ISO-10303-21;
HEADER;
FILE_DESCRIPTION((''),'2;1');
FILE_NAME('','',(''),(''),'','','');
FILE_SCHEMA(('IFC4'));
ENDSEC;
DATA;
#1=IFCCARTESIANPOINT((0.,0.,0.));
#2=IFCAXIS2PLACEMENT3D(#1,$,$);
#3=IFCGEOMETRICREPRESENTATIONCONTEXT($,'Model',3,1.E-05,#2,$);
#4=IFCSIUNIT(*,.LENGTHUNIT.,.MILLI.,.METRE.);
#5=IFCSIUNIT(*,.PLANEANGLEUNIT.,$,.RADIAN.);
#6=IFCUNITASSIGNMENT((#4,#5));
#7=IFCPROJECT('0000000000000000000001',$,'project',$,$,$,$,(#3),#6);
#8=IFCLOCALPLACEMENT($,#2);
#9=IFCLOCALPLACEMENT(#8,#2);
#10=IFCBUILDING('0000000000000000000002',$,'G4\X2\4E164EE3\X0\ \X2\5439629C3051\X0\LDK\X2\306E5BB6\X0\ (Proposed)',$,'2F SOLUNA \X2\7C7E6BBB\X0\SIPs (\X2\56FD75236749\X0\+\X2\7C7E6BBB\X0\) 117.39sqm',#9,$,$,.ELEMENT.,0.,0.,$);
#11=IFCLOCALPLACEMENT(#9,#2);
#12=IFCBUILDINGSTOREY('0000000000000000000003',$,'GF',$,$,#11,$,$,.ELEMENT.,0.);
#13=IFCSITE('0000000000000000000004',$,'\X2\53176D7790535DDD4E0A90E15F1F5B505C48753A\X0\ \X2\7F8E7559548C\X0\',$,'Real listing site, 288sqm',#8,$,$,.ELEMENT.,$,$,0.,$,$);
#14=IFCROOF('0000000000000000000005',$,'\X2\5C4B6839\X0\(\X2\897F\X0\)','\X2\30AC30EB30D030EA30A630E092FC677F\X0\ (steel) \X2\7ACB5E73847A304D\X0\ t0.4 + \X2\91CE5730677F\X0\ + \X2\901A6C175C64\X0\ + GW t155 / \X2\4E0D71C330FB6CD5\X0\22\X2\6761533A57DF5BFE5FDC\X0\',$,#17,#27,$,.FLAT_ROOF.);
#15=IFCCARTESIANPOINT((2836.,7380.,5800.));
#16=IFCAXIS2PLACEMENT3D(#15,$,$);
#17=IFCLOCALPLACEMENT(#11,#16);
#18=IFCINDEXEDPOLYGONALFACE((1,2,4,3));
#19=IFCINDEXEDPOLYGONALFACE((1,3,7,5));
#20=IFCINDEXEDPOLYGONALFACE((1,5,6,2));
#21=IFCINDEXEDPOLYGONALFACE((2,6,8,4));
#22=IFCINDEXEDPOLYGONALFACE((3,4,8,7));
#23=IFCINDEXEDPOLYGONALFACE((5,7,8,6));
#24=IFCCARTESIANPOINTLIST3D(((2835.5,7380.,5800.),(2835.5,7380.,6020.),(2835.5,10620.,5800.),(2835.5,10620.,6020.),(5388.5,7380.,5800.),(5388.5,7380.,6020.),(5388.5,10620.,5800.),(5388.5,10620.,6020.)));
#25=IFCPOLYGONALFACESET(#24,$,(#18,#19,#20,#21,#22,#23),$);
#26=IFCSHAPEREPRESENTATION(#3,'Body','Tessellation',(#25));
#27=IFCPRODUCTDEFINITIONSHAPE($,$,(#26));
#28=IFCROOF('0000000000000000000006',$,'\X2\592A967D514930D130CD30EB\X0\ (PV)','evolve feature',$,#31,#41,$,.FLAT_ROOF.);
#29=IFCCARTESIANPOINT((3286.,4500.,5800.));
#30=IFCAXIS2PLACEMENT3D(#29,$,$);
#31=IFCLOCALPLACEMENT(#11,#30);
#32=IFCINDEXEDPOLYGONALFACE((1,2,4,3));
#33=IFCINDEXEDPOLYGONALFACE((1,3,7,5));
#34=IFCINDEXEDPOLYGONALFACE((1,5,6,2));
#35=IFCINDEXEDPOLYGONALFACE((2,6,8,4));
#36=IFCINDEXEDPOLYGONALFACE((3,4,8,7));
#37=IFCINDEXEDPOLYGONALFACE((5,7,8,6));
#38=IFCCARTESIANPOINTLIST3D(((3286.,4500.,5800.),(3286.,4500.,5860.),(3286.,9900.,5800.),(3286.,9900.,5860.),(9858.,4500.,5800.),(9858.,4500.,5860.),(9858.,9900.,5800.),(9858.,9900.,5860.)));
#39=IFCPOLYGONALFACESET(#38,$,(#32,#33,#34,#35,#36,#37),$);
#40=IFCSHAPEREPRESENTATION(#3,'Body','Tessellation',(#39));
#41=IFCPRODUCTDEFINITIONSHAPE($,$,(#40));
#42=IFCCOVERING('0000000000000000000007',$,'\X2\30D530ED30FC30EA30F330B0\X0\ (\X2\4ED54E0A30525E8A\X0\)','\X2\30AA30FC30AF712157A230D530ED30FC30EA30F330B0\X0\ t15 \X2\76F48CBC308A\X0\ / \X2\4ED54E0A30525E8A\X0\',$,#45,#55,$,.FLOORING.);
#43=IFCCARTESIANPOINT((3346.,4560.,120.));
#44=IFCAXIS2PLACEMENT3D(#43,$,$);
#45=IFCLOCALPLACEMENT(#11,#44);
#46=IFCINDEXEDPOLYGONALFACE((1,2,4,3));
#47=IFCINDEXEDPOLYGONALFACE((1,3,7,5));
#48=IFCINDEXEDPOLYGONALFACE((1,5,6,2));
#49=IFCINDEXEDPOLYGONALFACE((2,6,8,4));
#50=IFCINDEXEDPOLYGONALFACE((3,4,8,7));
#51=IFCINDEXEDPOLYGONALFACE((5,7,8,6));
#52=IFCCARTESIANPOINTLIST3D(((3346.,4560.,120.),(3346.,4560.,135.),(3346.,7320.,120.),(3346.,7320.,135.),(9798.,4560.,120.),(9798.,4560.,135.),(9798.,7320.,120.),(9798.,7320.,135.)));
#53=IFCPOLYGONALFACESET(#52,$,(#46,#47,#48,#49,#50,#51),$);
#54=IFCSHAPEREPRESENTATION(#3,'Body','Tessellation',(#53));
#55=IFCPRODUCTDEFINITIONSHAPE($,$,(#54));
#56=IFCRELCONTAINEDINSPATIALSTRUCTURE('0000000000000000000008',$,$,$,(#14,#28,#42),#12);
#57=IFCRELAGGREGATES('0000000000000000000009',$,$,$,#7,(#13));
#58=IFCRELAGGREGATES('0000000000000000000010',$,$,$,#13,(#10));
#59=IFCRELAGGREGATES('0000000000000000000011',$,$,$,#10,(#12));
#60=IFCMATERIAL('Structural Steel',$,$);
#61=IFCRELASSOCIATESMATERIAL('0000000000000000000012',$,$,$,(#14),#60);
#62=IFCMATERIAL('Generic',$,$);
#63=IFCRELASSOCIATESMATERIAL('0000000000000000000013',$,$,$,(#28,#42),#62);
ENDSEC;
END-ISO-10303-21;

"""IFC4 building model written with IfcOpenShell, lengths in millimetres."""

from ifc_helpers import new_model, si_unit, frame, frame_2d, origin, place, context, project, spatial, rectangle, extrude, material, element, save


model = new_model("IFC4")

# Units and contexts
model_context = context("Model", 3, precision=1e-05, world=origin())
ifc_project = project(units=[si_unit("LENGTHUNIT", "METRE", prefix="MILLI"), si_unit("PLANEANGLEUNIT", "RADIAN")], contexts=[model_context])

# Site, building, storey
site_placement = place(None, origin())
site = spatial("IfcSite", under=ifc_project, at=site_placement, Name="北海道川上郡弟子屈町 美留和", ObjectType="Real listing site, 288sqm", CompositionType="ELEMENT", RefElevation=0.0)
building_placement = place(site_placement, origin())
building = spatial("IfcBuilding", under=site, at=building_placement, Name="G4世代 吹抜けLDKの家 (Proposed)", ObjectType="2F SOLUNA 籾殻SIPs (国産杉+籾殻) 117.39sqm", CompositionType="ELEMENT", ElevationOfRefHeight=0.0, ElevationOfTerrain=0.0)
storey_placement = place(building_placement, origin())
storey = spatial("IfcBuildingStorey", under=building, at=storey_placement, Name="GF", CompositionType="ELEMENT", Elevation=0.0)

# Shared definitions
ifc_material_1 = material(Name="Generic")

# Roofs
ifc_material_2 = material(Name="Structural Steel")
roof_1_placement = place(storey_placement, frame((2836.0, 7380.0, 5800.0)))
element("IfcRoof", 1, at=roof_1_placement, inside=storey, material=ifc_material_2, Name="屋根(西)", Description="ガルバリウム鋼板 (steel) 立平葺き t0.4 + 野地板 + 通気層 + GW t155 / 不燃・法22条区域対応", PredefinedType="FLAT_ROOF", context=model_context, shape_type="SweptSolid", body=[
    extrude(rectangle(XDim=2553.0, YDim=3240.0, at=frame_2d((1276.0, 1620.0))), frame((2836.0, 7380.0, 5800.0)), (0.0, 0.0, 1.0), 220.0),
])
roof_2_placement = place(storey_placement, frame((3286.0, 4500.0, 5800.0)))
element("IfcRoof", 2, at=roof_2_placement, inside=storey, material=ifc_material_1, Name="太陽光パネル (PV)", Description="evolve feature", PredefinedType="FLAT_ROOF", context=model_context, shape_type="SweptSolid", body=[
    extrude(rectangle(XDim=6572.0, YDim=5400.0, at=frame_2d((3286.0, 2700.0))), frame((3286.0, 4500.0, 5800.0)), (0.0, 0.0, 1.0), 60.0),
])

# Covering
covering_placement = place(storey_placement, frame((3346.0, 4560.0, 120.0)))
element("IfcCovering", 3, at=covering_placement, inside=storey, material=ifc_material_1, Name="フローリング (仕上げ床)", Description="オーク無垢フローリング t15 直貼り / 仕上げ床", PredefinedType="FLOORING", context=model_context, shape_type="SweptSolid", body=[
    extrude(rectangle(XDim=6452.0, YDim=2760.0, at=frame_2d((3226.0, 1380.0))), frame((3346.0, 4560.0, 120.0)), (0.0, 0.0, 1.0), 15.0),
])

save(model, "model.ifc")
